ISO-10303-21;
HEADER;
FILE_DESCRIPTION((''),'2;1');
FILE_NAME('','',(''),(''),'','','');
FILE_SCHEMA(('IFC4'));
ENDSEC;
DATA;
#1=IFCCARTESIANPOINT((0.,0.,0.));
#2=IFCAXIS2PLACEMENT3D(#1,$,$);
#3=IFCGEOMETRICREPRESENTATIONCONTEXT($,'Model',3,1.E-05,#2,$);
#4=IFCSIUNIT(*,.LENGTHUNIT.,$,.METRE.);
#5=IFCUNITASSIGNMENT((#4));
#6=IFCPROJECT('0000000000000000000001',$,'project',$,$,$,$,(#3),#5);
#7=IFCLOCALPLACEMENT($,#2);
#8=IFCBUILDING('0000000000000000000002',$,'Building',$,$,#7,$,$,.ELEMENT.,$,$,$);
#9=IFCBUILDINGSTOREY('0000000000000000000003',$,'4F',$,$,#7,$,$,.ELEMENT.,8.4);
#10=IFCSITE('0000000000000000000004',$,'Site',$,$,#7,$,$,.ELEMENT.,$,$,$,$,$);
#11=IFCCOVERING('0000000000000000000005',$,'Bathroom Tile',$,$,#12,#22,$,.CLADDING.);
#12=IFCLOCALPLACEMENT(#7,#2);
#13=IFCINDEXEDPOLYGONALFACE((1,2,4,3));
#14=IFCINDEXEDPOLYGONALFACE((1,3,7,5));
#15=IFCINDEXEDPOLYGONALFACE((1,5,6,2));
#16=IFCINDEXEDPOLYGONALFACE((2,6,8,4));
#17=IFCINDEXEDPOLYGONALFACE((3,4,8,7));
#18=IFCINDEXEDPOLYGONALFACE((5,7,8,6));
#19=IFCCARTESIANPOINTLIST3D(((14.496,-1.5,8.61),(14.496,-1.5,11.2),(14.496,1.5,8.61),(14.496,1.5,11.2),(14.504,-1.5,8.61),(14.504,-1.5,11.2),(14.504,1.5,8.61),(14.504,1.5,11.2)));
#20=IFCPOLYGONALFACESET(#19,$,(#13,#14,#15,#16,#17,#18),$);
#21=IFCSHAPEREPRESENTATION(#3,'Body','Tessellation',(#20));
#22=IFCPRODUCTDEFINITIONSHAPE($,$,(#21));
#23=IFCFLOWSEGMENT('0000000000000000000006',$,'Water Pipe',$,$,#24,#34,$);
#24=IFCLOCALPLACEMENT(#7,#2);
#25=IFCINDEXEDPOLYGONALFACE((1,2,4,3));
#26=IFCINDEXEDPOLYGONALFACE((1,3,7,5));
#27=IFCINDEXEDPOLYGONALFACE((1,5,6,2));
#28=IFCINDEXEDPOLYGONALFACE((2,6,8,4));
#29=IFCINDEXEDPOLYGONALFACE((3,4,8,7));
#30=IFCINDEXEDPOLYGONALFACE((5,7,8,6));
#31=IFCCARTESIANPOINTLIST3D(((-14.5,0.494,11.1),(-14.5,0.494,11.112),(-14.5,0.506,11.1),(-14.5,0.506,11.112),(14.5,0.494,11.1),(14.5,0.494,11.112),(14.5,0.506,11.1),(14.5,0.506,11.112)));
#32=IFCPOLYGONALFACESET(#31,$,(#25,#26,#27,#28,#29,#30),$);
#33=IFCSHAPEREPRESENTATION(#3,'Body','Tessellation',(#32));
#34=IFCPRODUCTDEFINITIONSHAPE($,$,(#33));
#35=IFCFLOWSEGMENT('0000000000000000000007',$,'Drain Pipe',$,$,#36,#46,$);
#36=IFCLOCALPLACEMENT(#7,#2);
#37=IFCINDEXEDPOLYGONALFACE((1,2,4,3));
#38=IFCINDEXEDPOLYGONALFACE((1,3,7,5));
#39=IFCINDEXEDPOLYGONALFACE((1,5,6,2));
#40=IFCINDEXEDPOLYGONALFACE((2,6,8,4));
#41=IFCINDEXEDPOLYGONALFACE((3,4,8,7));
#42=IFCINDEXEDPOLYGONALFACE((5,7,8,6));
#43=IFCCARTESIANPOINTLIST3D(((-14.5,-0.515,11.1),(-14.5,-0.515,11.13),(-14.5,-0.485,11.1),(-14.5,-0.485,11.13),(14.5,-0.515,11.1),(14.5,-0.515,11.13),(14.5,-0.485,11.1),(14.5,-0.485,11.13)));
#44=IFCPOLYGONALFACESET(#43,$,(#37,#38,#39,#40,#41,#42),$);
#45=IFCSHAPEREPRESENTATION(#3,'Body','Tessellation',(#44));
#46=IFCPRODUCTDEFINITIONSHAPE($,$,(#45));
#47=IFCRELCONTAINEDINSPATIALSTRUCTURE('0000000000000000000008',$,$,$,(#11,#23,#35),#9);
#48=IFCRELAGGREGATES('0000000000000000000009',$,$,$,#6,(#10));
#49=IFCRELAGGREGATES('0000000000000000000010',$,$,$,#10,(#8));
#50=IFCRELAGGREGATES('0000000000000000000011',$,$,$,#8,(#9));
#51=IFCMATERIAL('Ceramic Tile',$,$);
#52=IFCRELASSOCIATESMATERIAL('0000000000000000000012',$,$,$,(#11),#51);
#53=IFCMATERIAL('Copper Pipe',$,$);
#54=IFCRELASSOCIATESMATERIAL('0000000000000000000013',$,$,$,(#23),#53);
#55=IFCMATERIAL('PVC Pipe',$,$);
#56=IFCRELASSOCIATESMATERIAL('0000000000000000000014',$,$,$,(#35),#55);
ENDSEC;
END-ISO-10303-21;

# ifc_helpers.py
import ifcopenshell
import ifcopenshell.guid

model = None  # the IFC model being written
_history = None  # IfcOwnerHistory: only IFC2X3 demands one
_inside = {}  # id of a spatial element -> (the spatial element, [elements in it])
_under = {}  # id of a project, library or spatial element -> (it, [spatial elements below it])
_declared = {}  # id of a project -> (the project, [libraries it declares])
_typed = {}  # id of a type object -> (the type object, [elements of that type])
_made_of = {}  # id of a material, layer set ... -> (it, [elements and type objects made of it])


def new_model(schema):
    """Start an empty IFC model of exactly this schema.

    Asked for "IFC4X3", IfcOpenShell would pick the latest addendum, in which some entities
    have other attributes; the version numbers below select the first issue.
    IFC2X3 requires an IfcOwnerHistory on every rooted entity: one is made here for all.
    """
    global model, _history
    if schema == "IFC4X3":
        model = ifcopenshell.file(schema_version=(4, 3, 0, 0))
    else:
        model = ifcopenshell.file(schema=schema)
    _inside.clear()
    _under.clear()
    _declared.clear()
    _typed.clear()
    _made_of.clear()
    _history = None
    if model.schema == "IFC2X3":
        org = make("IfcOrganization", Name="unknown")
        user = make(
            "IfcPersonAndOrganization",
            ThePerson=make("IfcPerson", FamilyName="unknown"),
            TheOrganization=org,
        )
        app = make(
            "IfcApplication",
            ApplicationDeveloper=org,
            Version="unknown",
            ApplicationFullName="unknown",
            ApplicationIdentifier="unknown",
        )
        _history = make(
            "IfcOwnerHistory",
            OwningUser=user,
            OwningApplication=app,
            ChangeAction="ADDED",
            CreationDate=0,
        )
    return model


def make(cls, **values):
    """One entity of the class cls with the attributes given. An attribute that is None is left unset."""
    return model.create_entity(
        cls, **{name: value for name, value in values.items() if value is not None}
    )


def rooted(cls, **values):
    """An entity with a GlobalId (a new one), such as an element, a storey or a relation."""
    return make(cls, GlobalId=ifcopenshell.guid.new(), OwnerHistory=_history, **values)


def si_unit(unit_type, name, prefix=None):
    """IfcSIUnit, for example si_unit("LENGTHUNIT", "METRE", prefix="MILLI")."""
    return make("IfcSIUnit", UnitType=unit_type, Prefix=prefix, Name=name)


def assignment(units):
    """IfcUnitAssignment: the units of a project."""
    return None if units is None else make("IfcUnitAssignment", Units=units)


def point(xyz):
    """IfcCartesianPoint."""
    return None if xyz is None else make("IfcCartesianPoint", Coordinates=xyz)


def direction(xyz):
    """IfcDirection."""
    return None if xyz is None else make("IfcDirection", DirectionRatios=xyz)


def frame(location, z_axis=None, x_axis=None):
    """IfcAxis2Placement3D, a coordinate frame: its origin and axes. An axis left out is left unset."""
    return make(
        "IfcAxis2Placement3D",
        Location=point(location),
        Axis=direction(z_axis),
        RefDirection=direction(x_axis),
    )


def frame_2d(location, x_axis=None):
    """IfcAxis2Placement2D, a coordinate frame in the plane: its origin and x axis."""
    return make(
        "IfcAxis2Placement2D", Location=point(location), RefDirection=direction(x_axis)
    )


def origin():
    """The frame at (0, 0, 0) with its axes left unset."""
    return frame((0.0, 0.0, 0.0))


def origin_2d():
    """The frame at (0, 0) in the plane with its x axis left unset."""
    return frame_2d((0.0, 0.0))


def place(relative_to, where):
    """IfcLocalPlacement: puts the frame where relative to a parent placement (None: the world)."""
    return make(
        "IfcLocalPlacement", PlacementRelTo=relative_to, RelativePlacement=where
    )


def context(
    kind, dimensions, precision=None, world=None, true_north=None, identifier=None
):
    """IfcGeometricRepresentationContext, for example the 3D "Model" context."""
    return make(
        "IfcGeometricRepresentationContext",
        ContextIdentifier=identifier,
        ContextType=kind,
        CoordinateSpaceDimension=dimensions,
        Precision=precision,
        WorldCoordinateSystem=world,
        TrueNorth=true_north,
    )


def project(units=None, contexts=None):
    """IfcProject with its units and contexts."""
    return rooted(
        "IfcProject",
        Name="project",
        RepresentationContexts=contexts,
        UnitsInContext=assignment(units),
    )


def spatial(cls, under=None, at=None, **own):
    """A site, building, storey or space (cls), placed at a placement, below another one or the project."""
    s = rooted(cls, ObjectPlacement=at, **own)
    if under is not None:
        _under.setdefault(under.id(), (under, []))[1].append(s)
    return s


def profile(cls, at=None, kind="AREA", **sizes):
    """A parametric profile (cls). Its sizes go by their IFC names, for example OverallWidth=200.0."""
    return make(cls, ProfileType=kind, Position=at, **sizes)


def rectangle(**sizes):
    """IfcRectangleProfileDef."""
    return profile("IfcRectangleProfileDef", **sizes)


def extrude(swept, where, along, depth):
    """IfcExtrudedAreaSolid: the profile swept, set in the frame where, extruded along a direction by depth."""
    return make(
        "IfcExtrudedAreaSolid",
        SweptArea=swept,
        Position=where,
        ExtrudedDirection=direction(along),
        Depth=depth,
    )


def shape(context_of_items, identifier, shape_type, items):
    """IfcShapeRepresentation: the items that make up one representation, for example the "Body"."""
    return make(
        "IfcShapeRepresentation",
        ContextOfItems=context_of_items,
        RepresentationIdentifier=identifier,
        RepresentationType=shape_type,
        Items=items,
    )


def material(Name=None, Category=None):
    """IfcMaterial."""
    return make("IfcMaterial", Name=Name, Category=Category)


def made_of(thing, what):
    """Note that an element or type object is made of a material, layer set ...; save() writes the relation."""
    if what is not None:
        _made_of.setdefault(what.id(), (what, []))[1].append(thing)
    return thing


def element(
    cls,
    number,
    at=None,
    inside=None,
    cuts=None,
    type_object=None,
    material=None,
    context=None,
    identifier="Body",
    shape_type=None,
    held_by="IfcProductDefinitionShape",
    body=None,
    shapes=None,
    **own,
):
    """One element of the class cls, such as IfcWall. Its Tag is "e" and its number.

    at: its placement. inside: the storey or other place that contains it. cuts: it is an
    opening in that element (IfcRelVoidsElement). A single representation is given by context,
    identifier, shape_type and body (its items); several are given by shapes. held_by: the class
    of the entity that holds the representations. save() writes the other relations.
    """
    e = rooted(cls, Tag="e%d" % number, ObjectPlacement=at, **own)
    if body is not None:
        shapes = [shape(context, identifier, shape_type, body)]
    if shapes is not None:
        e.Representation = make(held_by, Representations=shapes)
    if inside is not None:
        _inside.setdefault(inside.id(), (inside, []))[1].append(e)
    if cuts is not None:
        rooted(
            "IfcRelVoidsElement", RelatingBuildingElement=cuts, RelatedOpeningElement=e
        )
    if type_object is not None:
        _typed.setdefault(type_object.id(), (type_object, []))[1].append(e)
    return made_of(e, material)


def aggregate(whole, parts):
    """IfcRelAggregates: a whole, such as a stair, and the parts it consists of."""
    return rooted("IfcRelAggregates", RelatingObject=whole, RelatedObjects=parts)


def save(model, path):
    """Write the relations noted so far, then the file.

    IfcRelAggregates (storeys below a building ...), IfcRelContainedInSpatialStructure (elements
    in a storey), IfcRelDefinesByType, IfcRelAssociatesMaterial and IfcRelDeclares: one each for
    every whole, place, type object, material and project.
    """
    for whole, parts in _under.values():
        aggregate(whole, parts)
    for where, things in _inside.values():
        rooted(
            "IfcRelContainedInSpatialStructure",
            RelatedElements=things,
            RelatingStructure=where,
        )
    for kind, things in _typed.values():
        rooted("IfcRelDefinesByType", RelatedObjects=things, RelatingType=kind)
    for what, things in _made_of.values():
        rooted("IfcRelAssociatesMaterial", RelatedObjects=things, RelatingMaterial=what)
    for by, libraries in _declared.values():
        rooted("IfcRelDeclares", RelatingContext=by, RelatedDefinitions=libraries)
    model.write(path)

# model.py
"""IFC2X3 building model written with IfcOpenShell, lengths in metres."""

from ifc_helpers import new_model, si_unit, frame, origin, origin_2d, place, context, project, spatial, rectangle, extrude, material, element, save


model = new_model("IFC2X3")

# Units and contexts
model_context = context("Model", 3, precision=1e-05, world=origin())
ifc_project = project(units=[si_unit("LENGTHUNIT", "METRE")], contexts=[model_context])

# Site, building, storey
placement = place(None, origin())
site = spatial("IfcSite", under=ifc_project, at=placement, Name="Site", CompositionType="ELEMENT")
building = spatial("IfcBuilding", under=site, at=placement, Name="Building", CompositionType="ELEMENT")
storey = spatial("IfcBuildingStorey", under=building, at=placement, Name="4F", CompositionType="ELEMENT", Elevation=8.4)

# Covering
ifc_material_1 = material(Name="Ceramic Tile")
covering_1_placement = place(None, frame((14.5, 0.0, 8.61)))
element("IfcCovering", 1, at=covering_1_placement, inside=storey, material=ifc_material_1, Name="Bathroom Tile", PredefinedType="CLADDING", context=model_context, shape_type="SweptSolid", body=[
    extrude(rectangle(XDim=0.008, YDim=3.0, at=origin_2d()), origin(), (0.0, 0.0, 1.0), 2.59),
])

# Flow segments
ifc_material_2 = material(Name="Copper Pipe")
flow_segment_1_placement = place(None, frame((0.0, 0.5, 11.1)))
element("IfcFlowSegment", 2, at=flow_segment_1_placement, inside=storey, material=ifc_material_2, Name="Water Pipe", context=model_context, shape_type="SweptSolid", body=[
    extrude(rectangle(XDim=29.0, YDim=0.012, at=origin_2d()), origin(), (0.0, 0.0, 1.0), 0.012),
])
ifc_material_3 = material(Name="PVC Pipe")
flow_segment_2_placement = place(None, frame((0.0, -0.5, 11.1)))
element("IfcFlowSegment", 3, at=flow_segment_2_placement, inside=storey, material=ifc_material_3, Name="Drain Pipe", context=model_context, shape_type="SweptSolid", body=[
    extrude(rectangle(XDim=29.0, YDim=0.03, at=origin_2d()), origin(), (0.0, 0.0, 1.0), 0.03),
])

save(model, "model.ifc")
